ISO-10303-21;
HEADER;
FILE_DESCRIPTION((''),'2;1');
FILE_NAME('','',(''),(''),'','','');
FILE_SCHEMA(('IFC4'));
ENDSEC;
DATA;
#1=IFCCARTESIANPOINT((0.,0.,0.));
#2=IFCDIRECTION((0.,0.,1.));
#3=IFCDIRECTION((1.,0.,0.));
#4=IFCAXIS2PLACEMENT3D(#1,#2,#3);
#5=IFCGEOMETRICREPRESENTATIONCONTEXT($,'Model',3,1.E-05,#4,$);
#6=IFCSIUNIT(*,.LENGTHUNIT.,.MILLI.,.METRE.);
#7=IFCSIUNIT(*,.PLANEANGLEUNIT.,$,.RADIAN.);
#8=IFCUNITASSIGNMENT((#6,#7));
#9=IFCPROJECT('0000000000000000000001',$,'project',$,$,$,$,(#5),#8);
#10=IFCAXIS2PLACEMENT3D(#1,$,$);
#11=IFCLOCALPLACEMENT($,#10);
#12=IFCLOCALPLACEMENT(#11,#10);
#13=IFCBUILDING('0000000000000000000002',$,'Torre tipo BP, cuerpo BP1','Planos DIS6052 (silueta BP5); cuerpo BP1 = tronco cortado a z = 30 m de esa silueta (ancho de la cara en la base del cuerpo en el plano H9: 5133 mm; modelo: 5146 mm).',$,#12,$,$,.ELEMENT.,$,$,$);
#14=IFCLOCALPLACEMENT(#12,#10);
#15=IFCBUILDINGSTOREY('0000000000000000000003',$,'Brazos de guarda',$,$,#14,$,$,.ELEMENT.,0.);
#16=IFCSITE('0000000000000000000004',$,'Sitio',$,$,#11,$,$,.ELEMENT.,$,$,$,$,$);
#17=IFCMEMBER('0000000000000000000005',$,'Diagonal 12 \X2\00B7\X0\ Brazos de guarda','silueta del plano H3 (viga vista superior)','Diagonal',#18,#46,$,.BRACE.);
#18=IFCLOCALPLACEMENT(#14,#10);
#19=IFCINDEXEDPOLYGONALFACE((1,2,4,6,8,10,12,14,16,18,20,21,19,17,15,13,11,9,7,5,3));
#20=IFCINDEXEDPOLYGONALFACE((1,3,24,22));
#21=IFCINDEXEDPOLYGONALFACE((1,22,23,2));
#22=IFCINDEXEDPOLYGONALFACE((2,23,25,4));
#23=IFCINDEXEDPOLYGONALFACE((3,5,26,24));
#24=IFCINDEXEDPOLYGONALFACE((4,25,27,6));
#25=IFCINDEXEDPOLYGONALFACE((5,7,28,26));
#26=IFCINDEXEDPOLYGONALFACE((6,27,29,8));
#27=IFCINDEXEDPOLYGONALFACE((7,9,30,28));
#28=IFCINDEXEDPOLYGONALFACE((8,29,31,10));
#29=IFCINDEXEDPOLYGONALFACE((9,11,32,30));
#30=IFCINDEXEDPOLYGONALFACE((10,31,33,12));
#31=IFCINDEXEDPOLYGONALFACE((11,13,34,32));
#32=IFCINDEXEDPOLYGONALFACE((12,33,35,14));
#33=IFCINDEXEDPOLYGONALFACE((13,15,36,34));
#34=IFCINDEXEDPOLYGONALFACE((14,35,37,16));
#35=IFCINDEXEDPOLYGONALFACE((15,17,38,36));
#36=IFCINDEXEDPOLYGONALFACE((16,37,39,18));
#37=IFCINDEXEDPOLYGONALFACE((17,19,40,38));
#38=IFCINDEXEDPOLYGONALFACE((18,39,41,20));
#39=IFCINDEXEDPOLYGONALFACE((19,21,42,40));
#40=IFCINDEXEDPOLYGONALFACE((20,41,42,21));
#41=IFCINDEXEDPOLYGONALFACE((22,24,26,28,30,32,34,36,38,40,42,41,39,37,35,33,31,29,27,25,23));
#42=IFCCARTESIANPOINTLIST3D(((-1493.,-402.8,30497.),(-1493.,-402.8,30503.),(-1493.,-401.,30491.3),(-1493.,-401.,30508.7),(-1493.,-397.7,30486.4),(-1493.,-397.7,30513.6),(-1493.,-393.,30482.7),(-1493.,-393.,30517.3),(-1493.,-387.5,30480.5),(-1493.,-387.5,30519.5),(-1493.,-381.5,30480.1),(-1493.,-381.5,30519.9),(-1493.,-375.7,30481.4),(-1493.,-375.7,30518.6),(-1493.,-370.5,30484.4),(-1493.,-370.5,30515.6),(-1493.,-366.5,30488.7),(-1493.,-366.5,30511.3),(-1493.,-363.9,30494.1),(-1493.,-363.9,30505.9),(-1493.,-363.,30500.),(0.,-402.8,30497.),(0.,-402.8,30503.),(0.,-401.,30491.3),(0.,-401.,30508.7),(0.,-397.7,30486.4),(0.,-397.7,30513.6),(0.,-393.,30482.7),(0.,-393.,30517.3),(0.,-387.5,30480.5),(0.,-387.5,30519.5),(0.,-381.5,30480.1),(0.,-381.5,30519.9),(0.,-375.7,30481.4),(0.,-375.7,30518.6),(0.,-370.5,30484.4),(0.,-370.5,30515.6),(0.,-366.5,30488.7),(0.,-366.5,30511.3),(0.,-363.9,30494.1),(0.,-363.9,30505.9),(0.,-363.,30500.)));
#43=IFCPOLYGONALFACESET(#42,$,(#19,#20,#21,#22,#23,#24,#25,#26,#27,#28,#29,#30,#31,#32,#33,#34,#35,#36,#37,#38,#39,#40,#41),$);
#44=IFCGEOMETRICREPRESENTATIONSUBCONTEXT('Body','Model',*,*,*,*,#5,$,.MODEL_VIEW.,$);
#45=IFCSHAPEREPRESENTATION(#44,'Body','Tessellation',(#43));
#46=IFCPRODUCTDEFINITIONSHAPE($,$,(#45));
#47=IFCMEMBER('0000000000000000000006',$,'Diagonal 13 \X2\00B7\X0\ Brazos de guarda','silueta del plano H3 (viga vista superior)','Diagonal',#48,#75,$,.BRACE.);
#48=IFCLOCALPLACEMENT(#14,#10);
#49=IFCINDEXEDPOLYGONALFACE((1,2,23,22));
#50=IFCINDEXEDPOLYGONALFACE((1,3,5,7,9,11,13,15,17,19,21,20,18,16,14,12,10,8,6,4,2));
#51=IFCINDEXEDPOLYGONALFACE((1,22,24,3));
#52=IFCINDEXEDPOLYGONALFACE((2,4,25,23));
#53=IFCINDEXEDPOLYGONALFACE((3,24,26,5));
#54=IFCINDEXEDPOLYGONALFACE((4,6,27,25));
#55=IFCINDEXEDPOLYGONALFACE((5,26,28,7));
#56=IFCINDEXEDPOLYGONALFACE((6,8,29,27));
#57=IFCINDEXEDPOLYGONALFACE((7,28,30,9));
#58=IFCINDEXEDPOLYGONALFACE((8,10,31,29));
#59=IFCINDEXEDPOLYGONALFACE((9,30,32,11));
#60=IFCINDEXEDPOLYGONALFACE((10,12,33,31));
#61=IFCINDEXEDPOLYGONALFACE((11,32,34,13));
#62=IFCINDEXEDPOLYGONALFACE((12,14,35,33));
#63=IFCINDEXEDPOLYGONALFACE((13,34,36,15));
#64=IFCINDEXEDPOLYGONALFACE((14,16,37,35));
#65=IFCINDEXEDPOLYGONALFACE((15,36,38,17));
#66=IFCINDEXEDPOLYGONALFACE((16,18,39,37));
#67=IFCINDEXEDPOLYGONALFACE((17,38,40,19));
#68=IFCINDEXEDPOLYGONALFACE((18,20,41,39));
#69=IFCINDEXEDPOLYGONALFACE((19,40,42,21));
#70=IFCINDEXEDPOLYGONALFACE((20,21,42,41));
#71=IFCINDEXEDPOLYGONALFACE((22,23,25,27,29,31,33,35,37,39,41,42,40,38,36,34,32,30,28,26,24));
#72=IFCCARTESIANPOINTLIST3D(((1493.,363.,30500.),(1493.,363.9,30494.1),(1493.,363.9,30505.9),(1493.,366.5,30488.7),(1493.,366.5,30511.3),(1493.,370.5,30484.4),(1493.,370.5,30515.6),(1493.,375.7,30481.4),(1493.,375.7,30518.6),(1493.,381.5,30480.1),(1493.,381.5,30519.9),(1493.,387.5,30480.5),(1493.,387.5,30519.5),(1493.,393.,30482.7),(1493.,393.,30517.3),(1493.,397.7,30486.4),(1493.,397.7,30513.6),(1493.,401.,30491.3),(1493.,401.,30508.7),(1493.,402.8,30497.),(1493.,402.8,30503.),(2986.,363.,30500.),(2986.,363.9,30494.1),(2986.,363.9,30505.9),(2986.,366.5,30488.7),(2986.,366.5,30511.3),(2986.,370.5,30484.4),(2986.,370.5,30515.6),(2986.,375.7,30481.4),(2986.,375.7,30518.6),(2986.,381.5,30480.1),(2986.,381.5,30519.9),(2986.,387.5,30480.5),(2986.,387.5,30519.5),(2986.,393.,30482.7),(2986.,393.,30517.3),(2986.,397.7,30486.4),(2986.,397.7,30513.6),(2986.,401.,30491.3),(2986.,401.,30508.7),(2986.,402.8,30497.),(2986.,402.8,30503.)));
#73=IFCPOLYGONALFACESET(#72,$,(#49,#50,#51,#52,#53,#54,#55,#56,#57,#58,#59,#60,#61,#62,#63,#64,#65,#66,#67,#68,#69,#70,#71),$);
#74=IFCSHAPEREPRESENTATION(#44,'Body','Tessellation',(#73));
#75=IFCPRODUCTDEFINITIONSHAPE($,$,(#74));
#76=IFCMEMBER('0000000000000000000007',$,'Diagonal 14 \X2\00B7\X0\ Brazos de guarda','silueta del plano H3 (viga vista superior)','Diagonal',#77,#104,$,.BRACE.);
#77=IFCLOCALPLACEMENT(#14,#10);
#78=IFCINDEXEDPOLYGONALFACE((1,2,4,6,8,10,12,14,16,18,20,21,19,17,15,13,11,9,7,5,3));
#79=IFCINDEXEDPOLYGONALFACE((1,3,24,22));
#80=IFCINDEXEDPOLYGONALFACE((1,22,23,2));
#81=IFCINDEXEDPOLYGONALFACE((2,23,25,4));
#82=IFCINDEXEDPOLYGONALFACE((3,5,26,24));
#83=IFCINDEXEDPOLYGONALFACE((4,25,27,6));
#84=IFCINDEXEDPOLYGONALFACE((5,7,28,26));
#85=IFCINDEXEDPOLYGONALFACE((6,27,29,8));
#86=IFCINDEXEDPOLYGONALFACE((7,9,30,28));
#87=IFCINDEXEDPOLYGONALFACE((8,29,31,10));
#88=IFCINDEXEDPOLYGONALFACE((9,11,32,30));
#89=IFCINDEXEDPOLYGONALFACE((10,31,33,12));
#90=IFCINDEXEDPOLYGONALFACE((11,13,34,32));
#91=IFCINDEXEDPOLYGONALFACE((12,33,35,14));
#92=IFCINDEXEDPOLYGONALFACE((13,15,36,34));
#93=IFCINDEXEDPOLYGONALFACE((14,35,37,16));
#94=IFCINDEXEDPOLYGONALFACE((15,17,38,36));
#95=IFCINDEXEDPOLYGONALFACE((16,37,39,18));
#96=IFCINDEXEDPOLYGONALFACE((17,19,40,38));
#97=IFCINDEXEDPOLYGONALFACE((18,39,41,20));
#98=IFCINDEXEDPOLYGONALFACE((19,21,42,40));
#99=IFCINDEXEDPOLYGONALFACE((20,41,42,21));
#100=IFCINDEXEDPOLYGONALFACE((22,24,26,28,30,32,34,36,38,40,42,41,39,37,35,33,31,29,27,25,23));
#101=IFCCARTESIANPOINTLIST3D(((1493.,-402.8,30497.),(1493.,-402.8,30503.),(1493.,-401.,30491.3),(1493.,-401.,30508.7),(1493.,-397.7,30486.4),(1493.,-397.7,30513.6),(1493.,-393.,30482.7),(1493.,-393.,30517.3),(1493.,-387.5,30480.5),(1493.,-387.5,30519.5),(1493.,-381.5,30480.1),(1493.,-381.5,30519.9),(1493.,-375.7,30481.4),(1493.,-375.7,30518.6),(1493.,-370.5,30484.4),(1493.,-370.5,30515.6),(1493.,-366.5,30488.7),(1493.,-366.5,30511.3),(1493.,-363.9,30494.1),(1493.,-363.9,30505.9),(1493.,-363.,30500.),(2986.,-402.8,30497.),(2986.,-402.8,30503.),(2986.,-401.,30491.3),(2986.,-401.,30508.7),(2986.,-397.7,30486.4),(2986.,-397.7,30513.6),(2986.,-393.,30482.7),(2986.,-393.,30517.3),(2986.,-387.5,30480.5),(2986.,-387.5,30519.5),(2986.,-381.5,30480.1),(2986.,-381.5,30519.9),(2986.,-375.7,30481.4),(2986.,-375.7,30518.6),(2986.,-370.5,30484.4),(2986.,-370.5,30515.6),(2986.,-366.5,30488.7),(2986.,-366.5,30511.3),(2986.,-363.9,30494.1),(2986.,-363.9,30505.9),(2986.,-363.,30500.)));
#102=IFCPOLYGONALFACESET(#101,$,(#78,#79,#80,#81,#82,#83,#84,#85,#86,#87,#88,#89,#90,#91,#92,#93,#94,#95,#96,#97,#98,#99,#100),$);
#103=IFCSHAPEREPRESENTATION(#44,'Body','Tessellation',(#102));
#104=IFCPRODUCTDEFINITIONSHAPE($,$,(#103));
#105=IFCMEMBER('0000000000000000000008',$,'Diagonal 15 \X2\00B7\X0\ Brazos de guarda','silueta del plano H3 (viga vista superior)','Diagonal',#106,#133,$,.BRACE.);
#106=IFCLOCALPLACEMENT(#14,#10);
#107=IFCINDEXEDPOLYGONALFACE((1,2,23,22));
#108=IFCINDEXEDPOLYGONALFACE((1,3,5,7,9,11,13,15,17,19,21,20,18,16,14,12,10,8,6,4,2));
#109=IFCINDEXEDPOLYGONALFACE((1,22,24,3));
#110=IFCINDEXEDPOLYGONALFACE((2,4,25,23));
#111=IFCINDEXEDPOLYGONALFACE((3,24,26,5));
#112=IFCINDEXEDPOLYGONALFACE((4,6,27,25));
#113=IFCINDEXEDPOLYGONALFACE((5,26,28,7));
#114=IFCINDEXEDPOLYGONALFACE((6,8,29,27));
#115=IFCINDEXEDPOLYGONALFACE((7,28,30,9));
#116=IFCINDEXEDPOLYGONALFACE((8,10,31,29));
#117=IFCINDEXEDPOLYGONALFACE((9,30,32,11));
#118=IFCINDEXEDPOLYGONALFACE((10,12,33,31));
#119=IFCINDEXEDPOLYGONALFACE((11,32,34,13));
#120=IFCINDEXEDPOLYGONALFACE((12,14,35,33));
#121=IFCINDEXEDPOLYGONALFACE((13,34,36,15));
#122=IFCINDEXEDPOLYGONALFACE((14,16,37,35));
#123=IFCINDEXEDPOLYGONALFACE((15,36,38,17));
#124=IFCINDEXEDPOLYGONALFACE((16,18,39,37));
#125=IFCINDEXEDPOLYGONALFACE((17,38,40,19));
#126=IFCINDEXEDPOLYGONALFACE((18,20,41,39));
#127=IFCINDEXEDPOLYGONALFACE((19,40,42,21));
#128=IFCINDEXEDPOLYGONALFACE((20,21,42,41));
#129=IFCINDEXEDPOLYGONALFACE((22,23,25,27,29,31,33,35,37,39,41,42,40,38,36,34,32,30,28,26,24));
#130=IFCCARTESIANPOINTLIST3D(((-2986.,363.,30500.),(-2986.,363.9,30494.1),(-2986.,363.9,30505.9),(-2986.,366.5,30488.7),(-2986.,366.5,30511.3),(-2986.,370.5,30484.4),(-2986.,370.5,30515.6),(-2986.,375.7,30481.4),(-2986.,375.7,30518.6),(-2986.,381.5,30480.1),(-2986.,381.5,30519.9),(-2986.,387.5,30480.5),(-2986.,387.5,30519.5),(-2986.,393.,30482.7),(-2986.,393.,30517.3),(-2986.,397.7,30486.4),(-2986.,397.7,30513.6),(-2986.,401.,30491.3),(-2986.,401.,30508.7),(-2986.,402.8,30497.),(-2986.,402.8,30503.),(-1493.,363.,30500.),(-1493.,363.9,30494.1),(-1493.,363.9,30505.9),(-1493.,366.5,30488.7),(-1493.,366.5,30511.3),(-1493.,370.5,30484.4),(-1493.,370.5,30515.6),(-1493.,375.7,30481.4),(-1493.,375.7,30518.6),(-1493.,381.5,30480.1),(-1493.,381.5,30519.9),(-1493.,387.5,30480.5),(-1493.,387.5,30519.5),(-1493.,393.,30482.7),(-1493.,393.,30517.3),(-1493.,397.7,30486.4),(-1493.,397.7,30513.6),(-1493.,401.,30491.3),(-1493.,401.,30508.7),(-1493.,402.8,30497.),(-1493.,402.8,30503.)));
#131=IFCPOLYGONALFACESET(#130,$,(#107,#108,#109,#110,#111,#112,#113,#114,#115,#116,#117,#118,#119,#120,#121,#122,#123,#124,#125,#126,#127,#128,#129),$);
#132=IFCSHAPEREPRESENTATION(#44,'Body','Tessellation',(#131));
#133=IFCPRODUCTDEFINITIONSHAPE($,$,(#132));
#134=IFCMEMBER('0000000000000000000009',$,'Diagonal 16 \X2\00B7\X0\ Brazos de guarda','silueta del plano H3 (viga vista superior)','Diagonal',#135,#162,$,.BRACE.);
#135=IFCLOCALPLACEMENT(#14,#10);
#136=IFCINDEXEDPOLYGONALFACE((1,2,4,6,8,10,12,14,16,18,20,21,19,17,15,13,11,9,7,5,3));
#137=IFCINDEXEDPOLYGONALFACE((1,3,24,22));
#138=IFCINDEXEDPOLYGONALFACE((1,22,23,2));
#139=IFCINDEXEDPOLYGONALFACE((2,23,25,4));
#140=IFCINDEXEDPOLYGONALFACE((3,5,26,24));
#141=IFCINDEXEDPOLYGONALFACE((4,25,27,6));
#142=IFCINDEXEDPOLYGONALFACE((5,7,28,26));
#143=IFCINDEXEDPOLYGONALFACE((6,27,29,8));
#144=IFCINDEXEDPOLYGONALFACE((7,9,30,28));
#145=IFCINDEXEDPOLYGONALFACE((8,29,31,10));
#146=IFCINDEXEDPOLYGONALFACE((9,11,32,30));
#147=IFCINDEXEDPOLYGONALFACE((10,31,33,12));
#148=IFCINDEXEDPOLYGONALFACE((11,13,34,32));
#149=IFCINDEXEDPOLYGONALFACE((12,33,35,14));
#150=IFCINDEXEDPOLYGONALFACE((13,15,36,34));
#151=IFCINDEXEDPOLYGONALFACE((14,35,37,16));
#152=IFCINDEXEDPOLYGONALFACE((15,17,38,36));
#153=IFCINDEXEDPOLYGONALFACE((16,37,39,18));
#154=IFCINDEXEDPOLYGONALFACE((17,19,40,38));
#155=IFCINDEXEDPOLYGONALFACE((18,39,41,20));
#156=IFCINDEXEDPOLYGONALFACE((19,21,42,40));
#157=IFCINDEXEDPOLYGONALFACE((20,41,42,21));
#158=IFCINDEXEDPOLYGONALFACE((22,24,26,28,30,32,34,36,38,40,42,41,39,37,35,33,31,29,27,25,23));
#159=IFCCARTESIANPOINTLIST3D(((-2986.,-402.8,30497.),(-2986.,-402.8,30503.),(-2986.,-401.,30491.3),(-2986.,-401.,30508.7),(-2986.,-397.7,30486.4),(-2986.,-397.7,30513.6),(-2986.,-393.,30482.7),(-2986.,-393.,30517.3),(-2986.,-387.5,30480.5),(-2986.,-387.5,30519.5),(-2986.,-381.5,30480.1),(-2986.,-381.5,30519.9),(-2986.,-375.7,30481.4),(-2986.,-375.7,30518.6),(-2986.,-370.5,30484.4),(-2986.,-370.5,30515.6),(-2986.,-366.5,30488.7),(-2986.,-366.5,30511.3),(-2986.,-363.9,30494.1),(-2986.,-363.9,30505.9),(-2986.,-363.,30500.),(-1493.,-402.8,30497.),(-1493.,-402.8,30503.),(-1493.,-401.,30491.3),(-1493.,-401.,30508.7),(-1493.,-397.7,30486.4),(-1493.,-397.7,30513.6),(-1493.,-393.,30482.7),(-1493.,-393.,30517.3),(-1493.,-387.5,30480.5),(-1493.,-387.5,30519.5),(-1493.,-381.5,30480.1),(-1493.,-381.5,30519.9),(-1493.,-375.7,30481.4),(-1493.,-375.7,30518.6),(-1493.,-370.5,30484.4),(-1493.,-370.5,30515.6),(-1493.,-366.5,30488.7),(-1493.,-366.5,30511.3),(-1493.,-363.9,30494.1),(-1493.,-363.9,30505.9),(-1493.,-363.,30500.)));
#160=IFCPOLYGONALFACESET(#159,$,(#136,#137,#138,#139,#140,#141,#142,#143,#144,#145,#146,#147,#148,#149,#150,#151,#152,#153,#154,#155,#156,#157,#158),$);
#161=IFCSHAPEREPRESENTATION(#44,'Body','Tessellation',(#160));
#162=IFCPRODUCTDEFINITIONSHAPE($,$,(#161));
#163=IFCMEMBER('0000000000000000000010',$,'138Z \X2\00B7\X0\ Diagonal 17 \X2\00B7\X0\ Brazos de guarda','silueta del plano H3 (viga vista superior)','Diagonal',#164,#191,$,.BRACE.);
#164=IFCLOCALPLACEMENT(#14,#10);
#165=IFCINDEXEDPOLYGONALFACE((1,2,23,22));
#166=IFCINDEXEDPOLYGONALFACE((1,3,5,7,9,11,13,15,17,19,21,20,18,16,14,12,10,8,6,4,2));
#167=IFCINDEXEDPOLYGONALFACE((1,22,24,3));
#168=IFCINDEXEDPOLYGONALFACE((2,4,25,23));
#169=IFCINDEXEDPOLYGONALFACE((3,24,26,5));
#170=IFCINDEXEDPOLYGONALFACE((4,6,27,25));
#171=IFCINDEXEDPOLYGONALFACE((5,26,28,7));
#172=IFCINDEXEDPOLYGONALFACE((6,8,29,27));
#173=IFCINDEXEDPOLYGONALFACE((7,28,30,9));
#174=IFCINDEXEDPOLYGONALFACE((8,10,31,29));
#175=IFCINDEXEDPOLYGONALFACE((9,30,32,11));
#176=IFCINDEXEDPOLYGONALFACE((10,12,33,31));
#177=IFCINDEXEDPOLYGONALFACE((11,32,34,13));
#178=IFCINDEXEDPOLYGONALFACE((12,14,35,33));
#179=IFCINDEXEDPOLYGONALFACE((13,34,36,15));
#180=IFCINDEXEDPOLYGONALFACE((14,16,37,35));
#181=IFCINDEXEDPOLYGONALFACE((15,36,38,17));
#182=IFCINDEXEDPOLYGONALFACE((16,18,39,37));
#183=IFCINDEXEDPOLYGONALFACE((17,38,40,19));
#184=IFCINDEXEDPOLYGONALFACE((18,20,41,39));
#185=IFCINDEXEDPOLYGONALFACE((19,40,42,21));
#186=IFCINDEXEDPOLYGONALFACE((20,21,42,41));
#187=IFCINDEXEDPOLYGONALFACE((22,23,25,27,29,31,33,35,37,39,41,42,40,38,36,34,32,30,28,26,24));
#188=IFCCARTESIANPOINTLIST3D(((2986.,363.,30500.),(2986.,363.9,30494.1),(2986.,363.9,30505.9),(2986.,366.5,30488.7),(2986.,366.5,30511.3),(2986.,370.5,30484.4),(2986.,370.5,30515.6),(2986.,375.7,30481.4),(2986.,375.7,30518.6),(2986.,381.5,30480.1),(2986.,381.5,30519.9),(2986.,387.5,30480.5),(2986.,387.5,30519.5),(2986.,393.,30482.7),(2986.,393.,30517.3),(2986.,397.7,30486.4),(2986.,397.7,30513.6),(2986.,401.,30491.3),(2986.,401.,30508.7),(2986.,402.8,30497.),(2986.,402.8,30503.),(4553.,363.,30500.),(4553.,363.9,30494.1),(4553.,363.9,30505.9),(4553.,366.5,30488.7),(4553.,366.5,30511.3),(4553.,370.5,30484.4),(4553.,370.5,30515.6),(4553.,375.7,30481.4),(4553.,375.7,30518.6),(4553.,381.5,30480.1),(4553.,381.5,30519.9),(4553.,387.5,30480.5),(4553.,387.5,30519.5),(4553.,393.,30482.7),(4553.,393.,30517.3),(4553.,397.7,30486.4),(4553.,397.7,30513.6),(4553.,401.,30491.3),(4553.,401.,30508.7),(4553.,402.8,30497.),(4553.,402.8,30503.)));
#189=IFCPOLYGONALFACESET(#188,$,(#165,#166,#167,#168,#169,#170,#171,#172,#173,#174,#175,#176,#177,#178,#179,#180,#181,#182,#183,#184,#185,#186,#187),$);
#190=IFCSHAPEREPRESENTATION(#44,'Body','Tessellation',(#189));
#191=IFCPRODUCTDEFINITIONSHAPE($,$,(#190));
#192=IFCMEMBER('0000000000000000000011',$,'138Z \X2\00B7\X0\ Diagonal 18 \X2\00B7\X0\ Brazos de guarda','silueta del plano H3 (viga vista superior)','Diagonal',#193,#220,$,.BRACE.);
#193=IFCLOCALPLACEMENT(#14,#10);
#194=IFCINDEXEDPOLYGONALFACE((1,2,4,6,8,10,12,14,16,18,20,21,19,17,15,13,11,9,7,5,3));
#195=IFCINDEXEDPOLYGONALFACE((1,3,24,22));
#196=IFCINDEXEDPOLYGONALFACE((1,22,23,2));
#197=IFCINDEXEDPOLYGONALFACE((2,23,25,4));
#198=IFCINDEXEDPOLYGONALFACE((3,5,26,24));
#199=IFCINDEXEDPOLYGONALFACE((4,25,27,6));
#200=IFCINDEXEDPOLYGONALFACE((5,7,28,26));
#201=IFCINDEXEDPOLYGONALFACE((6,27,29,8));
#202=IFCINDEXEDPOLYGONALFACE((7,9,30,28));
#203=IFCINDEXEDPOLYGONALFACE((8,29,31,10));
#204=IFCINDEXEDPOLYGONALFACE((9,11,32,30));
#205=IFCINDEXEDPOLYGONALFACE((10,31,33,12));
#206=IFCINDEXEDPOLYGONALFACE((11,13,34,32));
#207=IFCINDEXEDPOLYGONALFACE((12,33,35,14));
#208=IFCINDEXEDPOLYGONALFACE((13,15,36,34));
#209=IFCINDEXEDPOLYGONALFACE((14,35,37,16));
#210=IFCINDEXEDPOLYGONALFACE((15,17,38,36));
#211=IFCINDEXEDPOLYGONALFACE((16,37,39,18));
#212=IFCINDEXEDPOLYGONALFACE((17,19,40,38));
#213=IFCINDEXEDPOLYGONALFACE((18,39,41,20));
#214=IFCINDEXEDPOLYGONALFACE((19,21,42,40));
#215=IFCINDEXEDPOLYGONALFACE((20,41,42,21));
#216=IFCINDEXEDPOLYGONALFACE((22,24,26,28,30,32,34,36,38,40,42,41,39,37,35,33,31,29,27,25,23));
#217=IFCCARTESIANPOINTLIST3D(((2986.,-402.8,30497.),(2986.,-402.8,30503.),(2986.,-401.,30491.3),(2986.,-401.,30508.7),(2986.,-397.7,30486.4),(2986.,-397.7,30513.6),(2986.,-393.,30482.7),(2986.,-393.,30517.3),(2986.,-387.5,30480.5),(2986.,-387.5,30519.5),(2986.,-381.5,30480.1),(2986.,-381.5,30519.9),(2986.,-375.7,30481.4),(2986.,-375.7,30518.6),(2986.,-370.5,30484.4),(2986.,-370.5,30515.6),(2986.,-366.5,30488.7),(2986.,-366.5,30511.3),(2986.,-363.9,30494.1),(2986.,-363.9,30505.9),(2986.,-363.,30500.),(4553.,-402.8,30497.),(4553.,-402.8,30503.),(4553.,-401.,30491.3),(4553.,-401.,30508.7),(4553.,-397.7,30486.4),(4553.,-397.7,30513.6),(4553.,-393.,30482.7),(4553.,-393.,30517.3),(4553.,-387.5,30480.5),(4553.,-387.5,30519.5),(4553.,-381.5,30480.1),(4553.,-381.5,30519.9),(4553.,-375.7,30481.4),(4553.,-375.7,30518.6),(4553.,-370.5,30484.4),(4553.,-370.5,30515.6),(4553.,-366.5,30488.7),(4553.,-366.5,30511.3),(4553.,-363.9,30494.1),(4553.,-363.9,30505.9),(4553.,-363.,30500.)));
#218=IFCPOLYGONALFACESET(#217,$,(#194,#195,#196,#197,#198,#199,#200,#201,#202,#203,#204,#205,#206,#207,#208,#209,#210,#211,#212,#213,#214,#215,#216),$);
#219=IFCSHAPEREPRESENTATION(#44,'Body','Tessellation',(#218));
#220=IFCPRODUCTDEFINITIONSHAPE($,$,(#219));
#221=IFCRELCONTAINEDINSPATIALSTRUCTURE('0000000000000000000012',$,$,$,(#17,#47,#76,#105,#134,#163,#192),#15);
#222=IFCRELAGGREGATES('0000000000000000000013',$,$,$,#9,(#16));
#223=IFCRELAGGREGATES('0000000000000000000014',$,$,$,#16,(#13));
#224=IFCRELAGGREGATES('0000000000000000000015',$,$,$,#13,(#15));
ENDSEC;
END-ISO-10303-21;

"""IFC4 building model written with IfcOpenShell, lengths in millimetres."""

from ifc_helpers import new_model, si_unit, frame, origin, origin_with_axes, place, context, subcontext, project, spatial, circle, extrude, element, save


model = new_model("IFC4")

# Units and contexts
model_context = context("Model", 3, precision=1e-05, world=origin_with_axes())
body_context = subcontext(model_context, "Body", "Model", "MODEL_VIEW")
ifc_project = project(units=[si_unit("LENGTHUNIT", "METRE", prefix="MILLI"), si_unit("PLANEANGLEUNIT", "RADIAN")], contexts=[model_context])

# Site, building, storey
site_placement = place(None, origin())
site = spatial("IfcSite", under=ifc_project, at=site_placement, Name="Sitio", CompositionType="ELEMENT")
building_placement = place(site_placement, origin())
building = spatial("IfcBuilding", under=site, at=building_placement, Name="Torre tipo BP, cuerpo BP1", Description="Planos DIS6052 (silueta BP5); cuerpo BP1 = tronco cortado a z = 30 m de esa silueta (ancho de la cara en la base del cuerpo en el plano H9: 5133 mm; modelo: 5146 mm).", CompositionType="ELEMENT")
storey_placement = place(building_placement, origin())
storey = spatial("IfcBuildingStorey", under=building, at=storey_placement, Name="Brazos de guarda", CompositionType="ELEMENT", Elevation=0.0)

# Members
for number, where, z_axis, x_axis, name in (
    (1, (0.0, -383.0, 30500.0), (-1.0, 0.0, 0.0), (0.0, 1.0, 0.0), "Diagonal 12 · Brazos de guarda"),
    (2, (1493.0, 383.0, 30500.0), (1.0, 0.0, 0.0), (0.0, -1.0, 0.0), "Diagonal 13 · Brazos de guarda"),
    (3, (1493.0, -383.0, 30500.0), (1.0, 0.0, 0.0), (0.0, 1.0, 0.0), "Diagonal 14 · Brazos de guarda"),
    (4, (-1493.0, 383.0, 30500.0), (-1.0, 0.0, 0.0), (0.0, -1.0, 0.0), "Diagonal 15 · Brazos de guarda"),
    (5, (-1493.0, -383.0, 30500.0), (-1.0, 0.0, 0.0), (0.0, 1.0, 0.0), "Diagonal 16 · Brazos de guarda"),
):
    element("IfcMember", number, at=place(storey_placement, frame(where, z_axis=z_axis, x_axis=x_axis)), inside=storey, Name=name, Description="silueta del plano H3 (viga vista superior)", ObjectType="Diagonal", PredefinedType="BRACE", context=body_context, shape_type="SweptSolid", body=[
        extrude(circle(Radius=20.0), None, (0.0, 0.0, 1.0), 1493.0),
    ])
for number, where, z_axis, x_axis, name in (
    (6, (2986.0, 383.0, 30500.0), (1.0, 0.0, 0.0), (0.0, -1.0, 0.0), "138Z · Diagonal 17 · Brazos de guarda"),
    (7, (2986.0, -383.0, 30500.0), (1.0, 0.0, 0.0), (0.0, 1.0, 0.0), "138Z · Diagonal 18 · Brazos de guarda"),
):
    element("IfcMember", number, at=place(storey_placement, frame(where, z_axis=z_axis, x_axis=x_axis)), inside=storey, Name=name, Description="silueta del plano H3 (viga vista superior)", ObjectType="Diagonal", PredefinedType="BRACE", context=body_context, shape_type="SweptSolid", body=[
        extrude(circle(Radius=20.0), None, (0.0, 0.0, 1.0), 1567.0),
    ])

save(model, "model.ifc")
